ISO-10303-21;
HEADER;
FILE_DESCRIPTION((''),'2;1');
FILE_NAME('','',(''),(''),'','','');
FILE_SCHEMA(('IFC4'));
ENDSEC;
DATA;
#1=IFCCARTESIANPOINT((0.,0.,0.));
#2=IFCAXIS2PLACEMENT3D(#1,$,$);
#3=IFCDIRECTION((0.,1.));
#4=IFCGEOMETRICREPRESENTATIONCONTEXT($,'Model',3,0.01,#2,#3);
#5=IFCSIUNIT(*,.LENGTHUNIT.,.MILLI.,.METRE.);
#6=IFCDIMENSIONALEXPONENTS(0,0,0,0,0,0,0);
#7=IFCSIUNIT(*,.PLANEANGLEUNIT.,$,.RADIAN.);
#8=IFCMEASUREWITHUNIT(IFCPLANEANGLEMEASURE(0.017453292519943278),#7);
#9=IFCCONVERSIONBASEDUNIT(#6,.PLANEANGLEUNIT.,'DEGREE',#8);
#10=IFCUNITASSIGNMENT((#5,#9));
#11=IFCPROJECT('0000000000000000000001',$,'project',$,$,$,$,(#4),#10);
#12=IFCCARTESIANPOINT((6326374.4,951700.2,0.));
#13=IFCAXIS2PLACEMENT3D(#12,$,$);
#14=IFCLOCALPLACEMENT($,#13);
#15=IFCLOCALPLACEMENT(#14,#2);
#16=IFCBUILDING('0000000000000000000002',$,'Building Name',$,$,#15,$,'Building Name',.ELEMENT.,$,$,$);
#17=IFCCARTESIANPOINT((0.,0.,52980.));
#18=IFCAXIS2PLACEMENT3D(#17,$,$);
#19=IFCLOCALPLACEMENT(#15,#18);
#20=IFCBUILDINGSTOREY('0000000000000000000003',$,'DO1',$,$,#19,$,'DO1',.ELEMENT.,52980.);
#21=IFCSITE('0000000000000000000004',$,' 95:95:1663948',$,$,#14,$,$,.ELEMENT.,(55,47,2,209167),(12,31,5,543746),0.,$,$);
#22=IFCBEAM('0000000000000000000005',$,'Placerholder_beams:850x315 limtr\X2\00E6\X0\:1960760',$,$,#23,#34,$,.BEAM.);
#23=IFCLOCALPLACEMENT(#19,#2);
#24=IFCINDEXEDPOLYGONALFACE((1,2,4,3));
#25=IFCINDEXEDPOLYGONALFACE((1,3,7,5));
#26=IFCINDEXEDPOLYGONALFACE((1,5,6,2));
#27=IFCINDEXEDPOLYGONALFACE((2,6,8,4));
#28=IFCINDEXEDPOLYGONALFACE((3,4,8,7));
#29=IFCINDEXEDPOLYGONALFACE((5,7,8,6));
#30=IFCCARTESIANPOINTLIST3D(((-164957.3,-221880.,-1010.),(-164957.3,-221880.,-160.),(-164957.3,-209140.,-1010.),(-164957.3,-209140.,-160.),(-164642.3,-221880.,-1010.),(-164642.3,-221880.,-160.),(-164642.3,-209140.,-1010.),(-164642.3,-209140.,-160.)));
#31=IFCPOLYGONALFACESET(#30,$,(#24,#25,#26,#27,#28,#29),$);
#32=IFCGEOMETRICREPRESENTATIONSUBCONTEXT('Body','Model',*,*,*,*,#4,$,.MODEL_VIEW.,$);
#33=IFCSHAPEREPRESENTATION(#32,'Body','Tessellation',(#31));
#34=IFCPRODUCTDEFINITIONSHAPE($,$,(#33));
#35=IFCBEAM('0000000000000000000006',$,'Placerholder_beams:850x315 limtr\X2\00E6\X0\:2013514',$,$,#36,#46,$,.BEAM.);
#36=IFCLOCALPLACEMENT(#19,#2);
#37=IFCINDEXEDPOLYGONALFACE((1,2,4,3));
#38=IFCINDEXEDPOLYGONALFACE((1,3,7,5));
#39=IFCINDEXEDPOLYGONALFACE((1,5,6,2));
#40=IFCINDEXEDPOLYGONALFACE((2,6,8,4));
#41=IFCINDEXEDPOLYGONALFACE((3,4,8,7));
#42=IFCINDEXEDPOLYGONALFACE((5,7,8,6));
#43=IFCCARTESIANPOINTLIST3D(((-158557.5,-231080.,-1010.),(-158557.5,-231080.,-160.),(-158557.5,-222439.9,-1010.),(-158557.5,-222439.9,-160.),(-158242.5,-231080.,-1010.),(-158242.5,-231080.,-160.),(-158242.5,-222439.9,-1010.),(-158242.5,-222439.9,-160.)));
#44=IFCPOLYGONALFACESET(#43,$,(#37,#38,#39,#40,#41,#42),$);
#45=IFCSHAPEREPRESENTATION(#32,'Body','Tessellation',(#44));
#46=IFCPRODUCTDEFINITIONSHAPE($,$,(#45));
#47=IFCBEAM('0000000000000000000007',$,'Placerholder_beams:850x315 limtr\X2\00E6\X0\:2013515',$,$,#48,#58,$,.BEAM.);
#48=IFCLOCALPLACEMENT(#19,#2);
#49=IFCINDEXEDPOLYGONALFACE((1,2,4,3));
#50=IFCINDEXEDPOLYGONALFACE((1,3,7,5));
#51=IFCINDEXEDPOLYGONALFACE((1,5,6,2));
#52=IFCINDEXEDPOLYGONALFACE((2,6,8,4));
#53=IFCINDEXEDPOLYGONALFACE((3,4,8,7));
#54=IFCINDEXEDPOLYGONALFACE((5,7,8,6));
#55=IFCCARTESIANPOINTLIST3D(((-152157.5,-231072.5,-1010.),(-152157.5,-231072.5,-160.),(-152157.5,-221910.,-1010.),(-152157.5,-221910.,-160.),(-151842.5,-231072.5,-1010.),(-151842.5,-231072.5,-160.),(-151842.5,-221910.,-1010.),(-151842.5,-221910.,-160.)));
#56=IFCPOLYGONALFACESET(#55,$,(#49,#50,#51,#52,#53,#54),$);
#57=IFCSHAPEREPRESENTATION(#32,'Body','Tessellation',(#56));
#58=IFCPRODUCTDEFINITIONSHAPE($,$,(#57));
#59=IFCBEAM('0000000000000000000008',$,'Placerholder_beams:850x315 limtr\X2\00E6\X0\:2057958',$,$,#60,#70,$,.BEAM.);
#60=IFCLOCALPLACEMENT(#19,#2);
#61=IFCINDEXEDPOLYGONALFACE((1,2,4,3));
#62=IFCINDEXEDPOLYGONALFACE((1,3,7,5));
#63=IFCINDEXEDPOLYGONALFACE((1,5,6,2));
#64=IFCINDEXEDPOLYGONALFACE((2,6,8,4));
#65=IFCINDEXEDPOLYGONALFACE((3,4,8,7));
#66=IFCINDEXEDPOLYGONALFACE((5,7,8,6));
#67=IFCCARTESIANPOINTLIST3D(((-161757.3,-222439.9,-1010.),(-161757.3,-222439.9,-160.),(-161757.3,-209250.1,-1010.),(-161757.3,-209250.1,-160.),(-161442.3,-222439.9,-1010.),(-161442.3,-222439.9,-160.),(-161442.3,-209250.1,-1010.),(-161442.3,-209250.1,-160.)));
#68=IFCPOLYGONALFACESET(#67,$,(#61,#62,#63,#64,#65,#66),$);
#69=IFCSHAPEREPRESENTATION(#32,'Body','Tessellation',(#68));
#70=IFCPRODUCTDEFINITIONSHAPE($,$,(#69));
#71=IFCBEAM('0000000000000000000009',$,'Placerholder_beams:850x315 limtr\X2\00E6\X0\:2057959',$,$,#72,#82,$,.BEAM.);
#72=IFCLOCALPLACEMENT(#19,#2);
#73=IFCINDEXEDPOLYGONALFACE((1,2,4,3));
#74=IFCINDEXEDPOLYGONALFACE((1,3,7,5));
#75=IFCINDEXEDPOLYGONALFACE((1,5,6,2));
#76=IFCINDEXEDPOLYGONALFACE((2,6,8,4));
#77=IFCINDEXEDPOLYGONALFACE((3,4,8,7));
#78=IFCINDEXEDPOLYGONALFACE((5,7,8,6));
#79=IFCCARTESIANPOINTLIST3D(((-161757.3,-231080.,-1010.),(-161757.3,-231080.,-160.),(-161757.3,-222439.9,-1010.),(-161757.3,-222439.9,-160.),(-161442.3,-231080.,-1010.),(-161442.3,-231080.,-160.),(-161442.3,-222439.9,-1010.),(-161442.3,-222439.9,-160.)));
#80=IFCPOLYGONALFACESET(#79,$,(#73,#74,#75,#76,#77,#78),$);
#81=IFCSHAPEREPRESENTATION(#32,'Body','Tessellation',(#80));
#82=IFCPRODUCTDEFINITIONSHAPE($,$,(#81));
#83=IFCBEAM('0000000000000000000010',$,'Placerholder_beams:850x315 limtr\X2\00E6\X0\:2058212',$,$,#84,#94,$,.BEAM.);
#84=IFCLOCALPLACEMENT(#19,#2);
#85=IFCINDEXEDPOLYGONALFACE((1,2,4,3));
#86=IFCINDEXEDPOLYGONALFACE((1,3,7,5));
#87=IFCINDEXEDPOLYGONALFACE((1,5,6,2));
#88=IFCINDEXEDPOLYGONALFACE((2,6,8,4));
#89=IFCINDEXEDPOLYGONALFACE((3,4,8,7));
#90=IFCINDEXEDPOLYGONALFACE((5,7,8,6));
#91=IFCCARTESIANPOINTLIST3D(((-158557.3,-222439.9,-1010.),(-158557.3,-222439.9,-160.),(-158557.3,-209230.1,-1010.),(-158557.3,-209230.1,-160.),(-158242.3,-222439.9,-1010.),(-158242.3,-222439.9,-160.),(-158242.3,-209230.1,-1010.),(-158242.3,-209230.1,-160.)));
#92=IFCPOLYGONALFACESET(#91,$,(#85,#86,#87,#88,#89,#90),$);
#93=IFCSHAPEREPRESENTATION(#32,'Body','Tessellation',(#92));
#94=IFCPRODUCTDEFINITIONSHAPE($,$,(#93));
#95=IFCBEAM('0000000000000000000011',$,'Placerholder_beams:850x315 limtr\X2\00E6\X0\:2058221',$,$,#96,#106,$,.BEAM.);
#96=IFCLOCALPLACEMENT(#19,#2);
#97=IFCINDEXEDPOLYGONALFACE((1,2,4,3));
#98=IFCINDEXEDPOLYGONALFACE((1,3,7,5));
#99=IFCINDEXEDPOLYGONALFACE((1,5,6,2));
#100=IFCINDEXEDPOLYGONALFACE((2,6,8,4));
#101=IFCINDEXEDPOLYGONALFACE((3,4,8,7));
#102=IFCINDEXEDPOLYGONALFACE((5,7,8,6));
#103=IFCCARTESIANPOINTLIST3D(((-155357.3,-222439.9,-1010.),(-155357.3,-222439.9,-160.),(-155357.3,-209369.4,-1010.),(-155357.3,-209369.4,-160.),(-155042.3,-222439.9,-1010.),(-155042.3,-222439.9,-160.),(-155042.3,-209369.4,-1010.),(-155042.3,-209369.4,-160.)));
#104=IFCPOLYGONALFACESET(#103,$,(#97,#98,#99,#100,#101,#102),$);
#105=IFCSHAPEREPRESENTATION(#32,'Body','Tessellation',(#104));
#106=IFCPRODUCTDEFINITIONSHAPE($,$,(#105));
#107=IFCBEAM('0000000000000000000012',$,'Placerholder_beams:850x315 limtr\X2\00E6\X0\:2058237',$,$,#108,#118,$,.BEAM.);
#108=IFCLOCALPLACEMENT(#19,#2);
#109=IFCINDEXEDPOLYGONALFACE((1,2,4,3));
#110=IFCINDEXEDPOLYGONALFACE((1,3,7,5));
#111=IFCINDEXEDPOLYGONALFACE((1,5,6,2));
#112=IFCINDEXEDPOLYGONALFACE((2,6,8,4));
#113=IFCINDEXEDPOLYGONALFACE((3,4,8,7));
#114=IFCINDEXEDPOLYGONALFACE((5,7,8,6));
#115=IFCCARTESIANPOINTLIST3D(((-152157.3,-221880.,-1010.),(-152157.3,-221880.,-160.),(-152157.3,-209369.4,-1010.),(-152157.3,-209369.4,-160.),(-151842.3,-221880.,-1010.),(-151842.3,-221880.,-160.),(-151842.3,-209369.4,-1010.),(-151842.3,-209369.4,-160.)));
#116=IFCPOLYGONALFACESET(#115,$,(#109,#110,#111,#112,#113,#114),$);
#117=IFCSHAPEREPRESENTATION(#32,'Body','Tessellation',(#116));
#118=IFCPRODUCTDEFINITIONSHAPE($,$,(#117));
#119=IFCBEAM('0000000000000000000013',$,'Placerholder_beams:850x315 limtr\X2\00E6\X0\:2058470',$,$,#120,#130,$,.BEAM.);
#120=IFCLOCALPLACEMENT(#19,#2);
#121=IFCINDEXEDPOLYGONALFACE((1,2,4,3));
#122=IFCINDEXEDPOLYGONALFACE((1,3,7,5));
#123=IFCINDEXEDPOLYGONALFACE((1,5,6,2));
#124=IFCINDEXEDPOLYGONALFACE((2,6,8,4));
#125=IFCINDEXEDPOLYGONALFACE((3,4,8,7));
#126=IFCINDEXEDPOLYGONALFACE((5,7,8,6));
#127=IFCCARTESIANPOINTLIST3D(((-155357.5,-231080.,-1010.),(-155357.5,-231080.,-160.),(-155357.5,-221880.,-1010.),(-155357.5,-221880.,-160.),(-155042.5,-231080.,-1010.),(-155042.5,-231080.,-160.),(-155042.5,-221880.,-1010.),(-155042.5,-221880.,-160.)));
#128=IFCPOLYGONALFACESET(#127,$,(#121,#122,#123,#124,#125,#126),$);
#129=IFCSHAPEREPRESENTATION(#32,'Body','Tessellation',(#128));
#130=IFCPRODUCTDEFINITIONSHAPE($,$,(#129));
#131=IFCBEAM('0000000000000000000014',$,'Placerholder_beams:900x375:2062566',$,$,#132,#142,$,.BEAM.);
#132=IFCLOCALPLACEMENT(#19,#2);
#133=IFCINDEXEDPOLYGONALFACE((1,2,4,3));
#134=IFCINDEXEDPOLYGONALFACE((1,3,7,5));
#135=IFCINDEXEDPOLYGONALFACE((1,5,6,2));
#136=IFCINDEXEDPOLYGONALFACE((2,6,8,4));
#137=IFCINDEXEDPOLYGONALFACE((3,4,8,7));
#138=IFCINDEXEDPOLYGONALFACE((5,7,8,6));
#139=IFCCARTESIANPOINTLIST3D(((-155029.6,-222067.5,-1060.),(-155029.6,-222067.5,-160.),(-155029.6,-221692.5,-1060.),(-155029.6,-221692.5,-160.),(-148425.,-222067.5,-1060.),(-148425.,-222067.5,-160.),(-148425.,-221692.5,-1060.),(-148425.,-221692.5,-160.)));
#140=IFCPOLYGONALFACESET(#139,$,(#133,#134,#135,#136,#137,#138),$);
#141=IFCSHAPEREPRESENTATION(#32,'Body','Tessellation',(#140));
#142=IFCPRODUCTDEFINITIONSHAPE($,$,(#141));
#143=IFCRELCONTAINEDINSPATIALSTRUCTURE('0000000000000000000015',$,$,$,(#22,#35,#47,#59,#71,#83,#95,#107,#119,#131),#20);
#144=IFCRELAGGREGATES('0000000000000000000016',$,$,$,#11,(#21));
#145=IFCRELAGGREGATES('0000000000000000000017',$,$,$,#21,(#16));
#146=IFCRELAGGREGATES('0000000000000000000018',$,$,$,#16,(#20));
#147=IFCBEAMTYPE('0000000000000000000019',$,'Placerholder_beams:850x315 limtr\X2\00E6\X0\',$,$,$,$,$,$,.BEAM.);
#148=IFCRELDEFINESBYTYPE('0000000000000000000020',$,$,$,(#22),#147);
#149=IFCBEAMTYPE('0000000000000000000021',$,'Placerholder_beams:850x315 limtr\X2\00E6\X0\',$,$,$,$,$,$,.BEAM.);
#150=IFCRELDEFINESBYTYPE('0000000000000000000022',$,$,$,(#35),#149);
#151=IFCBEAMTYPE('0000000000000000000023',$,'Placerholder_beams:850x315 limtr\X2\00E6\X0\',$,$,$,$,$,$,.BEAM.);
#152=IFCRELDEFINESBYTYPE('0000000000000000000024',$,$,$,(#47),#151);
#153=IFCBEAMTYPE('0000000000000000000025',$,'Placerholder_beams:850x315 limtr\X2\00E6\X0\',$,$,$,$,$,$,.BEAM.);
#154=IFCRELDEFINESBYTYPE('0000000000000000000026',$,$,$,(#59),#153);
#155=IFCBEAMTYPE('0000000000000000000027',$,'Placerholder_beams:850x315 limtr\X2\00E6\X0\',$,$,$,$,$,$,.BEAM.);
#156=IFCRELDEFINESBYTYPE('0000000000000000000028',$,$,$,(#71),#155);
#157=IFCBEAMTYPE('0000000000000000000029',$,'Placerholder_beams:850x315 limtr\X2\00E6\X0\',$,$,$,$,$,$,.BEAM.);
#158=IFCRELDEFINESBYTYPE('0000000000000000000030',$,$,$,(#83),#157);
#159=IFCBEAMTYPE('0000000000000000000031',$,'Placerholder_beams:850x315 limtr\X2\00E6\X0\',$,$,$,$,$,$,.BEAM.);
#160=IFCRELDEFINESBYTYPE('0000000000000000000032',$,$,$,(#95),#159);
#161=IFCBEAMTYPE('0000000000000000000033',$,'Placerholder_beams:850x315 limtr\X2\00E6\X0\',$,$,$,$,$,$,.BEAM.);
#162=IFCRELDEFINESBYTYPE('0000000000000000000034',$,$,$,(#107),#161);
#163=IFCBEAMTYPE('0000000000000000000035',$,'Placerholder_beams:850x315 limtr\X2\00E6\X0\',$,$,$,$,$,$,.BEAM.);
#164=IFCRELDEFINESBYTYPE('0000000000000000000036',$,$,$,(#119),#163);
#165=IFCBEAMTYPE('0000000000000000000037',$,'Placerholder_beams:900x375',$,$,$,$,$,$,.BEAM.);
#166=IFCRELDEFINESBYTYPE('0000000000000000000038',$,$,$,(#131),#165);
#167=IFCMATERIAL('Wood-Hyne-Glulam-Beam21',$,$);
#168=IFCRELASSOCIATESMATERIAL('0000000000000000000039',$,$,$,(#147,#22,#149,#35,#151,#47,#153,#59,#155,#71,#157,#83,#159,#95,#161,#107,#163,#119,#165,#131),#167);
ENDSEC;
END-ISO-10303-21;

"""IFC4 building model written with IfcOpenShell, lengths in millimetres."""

from ifc_helpers import new_model, entity, si_unit, converted_unit, direction, frame, origin, place, context, subcontext, project, spatial, indexed_curve, outline, extrude, source, transform, mapped, material, type_object, type_shapes, element, save


model = new_model("IFC4")

# Units and contexts
model_context = context("Model", 3, precision=0.01, world=origin(), true_north=direction((0.0, 1.0)))
body_context = subcontext(model_context, "Body", "Model", "MODEL_VIEW")
ifc_project = project(units=[si_unit("LENGTHUNIT", "METRE", prefix="MILLI"), converted_unit("PLANEANGLEUNIT", "DEGREE", entity("IfcPlaneAngleMeasure", 0.017453292519943278), si_unit("PLANEANGLEUNIT", "RADIAN"), dimensions=[0, 0, 0, 0, 0, 0, 0])], contexts=[model_context])

# Site, building, storey
site_placement = place(None, frame((6326374.4, 951700.2, 0.0)))
site = spatial("IfcSite", under=ifc_project, at=site_placement, Name=" 95:95:1663948", CompositionType="ELEMENT", RefLatitude=(55, 47, 2, 209167), RefLongitude=(12, 31, 5, 543746), RefElevation=0.0)
building_placement = place(site_placement, origin())
building = spatial("IfcBuilding", under=site, at=building_placement, Name="Building Name", LongName="Building Name", CompositionType="ELEMENT")
storey_placement = place(building_placement, frame((0.0, 0.0, 52980.0)))
storey = spatial("IfcBuildingStorey", under=building, at=storey_placement, Name="DO1", LongName="DO1", CompositionType="ELEMENT", Elevation=52980.0)

# Beams
ifc_material = material(Name="Wood-Hyne-Glulam-Beam21")
beam_type_1 = type_object("IfcBeamType", Name="Placerholder_beams:850x315 limtræ", PredefinedType="BEAM", material=ifc_material)
shared_shape_1 = source(origin(), body_context, "Body", "SweptSolid", [
    extrude(outline(indexed_curve([(-6370.0, -157.5), (6370.0, -157.5), (6370.0, 157.5), (-6370.0, 157.5), (-6370.0, -157.5)], self_intersect=False)), frame((110.0, 0.0, -425.0)), (0.0, 0.0, 1.0), 850.0),
])
type_shapes(beam_type_1, [shared_shape_1])
beam_1_placement = place(storey_placement, frame((-164799.8, -215620.0, -585.0), z_axis=(0.0, 0.0, 1.0), x_axis=(0.0, 1.0, 0.0)))
element("IfcBeam", 1, at=beam_1_placement, inside=storey, type_object=beam_type_1, material=ifc_material, Name="Placerholder_beams:850x315 limtræ:1960760", PredefinedType="BEAM", context=body_context, shape_type="MappedRepresentation", body=[
    mapped(shared_shape_1, transform((0.0, 0.0, 0.0), scale=1.0)),
])
beam_type_2 = type_object("IfcBeamType", Name="Placerholder_beams:850x315 limtræ", PredefinedType="BEAM", material=ifc_material)
shared_shape_2 = source(origin(), body_context, "Body", "SweptSolid", [
    extrude(outline(indexed_curve([(-4320.0, -157.5), (4320.0, -157.5), (4320.0, 157.5), (-4320.0, 157.5), (-4320.0, -157.5)], self_intersect=False)), frame((280.0, 0.0, -425.0)), (0.0, 0.0, 1.0), 850.0),
])
type_shapes(beam_type_2, [shared_shape_2])
beam_2_placement = place(storey_placement, frame((-158400.0, -226480.0, -585.0), z_axis=(0.0, 0.0, 1.0), x_axis=(0.0, -1.0, 0.0)))
element("IfcBeam", 2, at=beam_2_placement, inside=storey, type_object=beam_type_2, material=ifc_material, Name="Placerholder_beams:850x315 limtræ:2013514", PredefinedType="BEAM", context=body_context, shape_type="MappedRepresentation", body=[
    mapped(shared_shape_2, transform((0.0, 0.0, 0.0), scale=1.0)),
])
beam_type_3 = type_object("IfcBeamType", Name="Placerholder_beams:850x315 limtræ", PredefinedType="BEAM", material=ifc_material)
shared_shape_3 = source(origin(), body_context, "Body", "SweptSolid", [
    extrude(outline(indexed_curve([(-4581.2, -157.5), (4581.2, -157.5), (4581.2, 157.5), (-4581.2, 157.5), (-4581.2, -157.5)], self_intersect=False)), frame((1588.8, 0.0, -425.0)), (0.0, 0.0, 1.0), 850.0),
])
type_shapes(beam_type_3, [shared_shape_3])
beam_3_placement = place(storey_placement, frame((-152000.0, -224902.5, -585.0), z_axis=(0.0, 0.0, 1.0), x_axis=(0.0, -1.0, 0.0)))
element("IfcBeam", 3, at=beam_3_placement, inside=storey, type_object=beam_type_3, material=ifc_material, Name="Placerholder_beams:850x315 limtræ:2013515", PredefinedType="BEAM", context=body_context, shape_type="MappedRepresentation", body=[
    mapped(shared_shape_3, transform((0.0, 0.0, 0.0), scale=1.0)),
])
beam_type_4 = type_object("IfcBeamType", Name="Placerholder_beams:850x315 limtræ", PredefinedType="BEAM", material=ifc_material)
shared_shape_4 = source(origin(), body_context, "Body", "SweptSolid", [
    extrude(outline(indexed_curve([(-6594.9, -157.5), (6594.9, -157.5), (6594.9, 157.5), (-6594.9, 157.5), (-6594.9, -157.5)], self_intersect=False)), frame((55.0, 0.0, -425.0)), (0.0, 0.0, 1.0), 850.0),
])
type_shapes(beam_type_4, [shared_shape_4])
beam_4_placement = place(storey_placement, frame((-161599.8, -215900.0, -585.0), z_axis=(0.0, 0.0, 1.0), x_axis=(0.0, 1.0, 0.0)))
element("IfcBeam", 4, at=beam_4_placement, inside=storey, type_object=beam_type_4, material=ifc_material, Name="Placerholder_beams:850x315 limtræ:2057958", PredefinedType="BEAM", context=body_context, shape_type="MappedRepresentation", body=[
    mapped(shared_shape_4, transform((0.0, 0.0, 0.0), scale=1.0)),
])
beam_type_5 = type_object("IfcBeamType", Name="Placerholder_beams:850x315 limtræ", PredefinedType="BEAM", material=ifc_material)
shared_shape_5 = source(origin(), body_context, "Body", "SweptSolid", [
    extrude(outline(indexed_curve([(-4320.0, -157.5), (4320.0, -157.5), (4320.0, 157.5), (-4320.0, 157.5), (-4320.0, -157.5)], self_intersect=False)), frame((0.0, 0.0, -425.0)), (0.0, 0.0, 1.0), 850.0),
])
type_shapes(beam_type_5, [shared_shape_5])
beam_5_placement = place(storey_placement, frame((-161599.8, -226760.0, -585.0), z_axis=(0.0, 0.0, 1.0), x_axis=(0.0, 1.0, 0.0)))
element("IfcBeam", 5, at=beam_5_placement, inside=storey, type_object=beam_type_5, material=ifc_material, Name="Placerholder_beams:850x315 limtræ:2057959", PredefinedType="BEAM", context=body_context, shape_type="MappedRepresentation", body=[
    mapped(shared_shape_5, transform((0.0, 0.0, 0.0), scale=1.0)),
])
beam_type_6 = type_object("IfcBeamType", Name="Placerholder_beams:850x315 limtræ", PredefinedType="BEAM", material=ifc_material)
shared_shape_6 = source(origin(), body_context, "Body", "SweptSolid", [
    extrude(outline(indexed_curve([(-6604.9, -157.5), (6604.9, -157.5), (6604.9, 157.5), (-6604.9, 157.5), (-6604.9, -157.5)], self_intersect=False)), frame((65.0, 0.0, -425.0)), (0.0, 0.0, 1.0), 850.0),
])
type_shapes(beam_type_6, [shared_shape_6])
beam_6_placement = place(storey_placement, frame((-158399.8, -215900.0, -585.0), z_axis=(0.0, 0.0, 1.0), x_axis=(0.0, 1.0, 0.0)))
element("IfcBeam", 6, at=beam_6_placement, inside=storey, type_object=beam_type_6, material=ifc_material, Name="Placerholder_beams:850x315 limtræ:2058212", PredefinedType="BEAM", context=body_context, shape_type="MappedRepresentation", body=[
    mapped(shared_shape_6, transform((0.0, 0.0, 0.0), scale=1.0)),
])
beam_type_7 = type_object("IfcBeamType", Name="Placerholder_beams:850x315 limtræ", PredefinedType="BEAM", material=ifc_material)
shared_shape_7 = source(origin(), body_context, "Body", "SweptSolid", [
    extrude(outline(indexed_curve([(-6535.3, -157.5), (6535.3, -157.5), (6535.3, 157.5), (-6535.3, 157.5), (-6535.3, -157.5)], self_intersect=False)), frame((-4.7, 0.0, -425.0)), (0.0, 0.0, 1.0), 850.0),
])
type_shapes(beam_type_7, [shared_shape_7])
beam_7_placement = place(storey_placement, frame((-155199.8, -215900.0, -585.0), z_axis=(0.0, 0.0, 1.0), x_axis=(0.0, 1.0, 0.0)))
element("IfcBeam", 7, at=beam_7_placement, inside=storey, type_object=beam_type_7, material=ifc_material, Name="Placerholder_beams:850x315 limtræ:2058221", PredefinedType="BEAM", context=body_context, shape_type="MappedRepresentation", body=[
    mapped(shared_shape_7, transform((0.0, 0.0, 0.0), scale=1.0)),
])
beam_type_8 = type_object("IfcBeamType", Name="Placerholder_beams:850x315 limtræ", PredefinedType="BEAM", material=ifc_material)
shared_shape_8 = source(origin(), body_context, "Body", "SweptSolid", [
    extrude(outline(indexed_curve([(-6255.3, -157.5), (6255.3, -157.5), (6255.3, 157.5), (-6255.3, 157.5), (-6255.3, -157.5)], self_intersect=False)), frame((275.3, 0.0, -425.0)), (0.0, 0.0, 1.0), 850.0),
])
type_shapes(beam_type_8, [shared_shape_8])
beam_8_placement = place(storey_placement, frame((-151999.8, -215900.0, -585.0), z_axis=(0.0, 0.0, 1.0), x_axis=(0.0, 1.0, 0.0)))
element("IfcBeam", 8, at=beam_8_placement, inside=storey, type_object=beam_type_8, material=ifc_material, Name="Placerholder_beams:850x315 limtræ:2058237", PredefinedType="BEAM", context=body_context, shape_type="MappedRepresentation", body=[
    mapped(shared_shape_8, transform((0.0, 0.0, 0.0), scale=1.0)),
])
beam_type_9 = type_object("IfcBeamType", Name="Placerholder_beams:850x315 limtræ", PredefinedType="BEAM", material=ifc_material)
shared_shape_9 = source(origin(), body_context, "Body", "SweptSolid", [
    extrude(outline(indexed_curve([(-4600.0, -157.5), (4600.0, -157.5), (4600.0, 157.5), (-4600.0, 157.5), (-4600.0, -157.5)], self_intersect=False)), frame((0.0, 0.0, -425.0)), (0.0, 0.0, 1.0), 850.0),
])
type_shapes(beam_type_9, [shared_shape_9])
beam_9_placement = place(storey_placement, frame((-155200.0, -226480.0, -585.0), z_axis=(0.0, 0.0, 1.0), x_axis=(0.0, -1.0, 0.0)))
element("IfcBeam", 9, at=beam_9_placement, inside=storey, type_object=beam_type_9, material=ifc_material, Name="Placerholder_beams:850x315 limtræ:2058470", PredefinedType="BEAM", context=body_context, shape_type="MappedRepresentation", body=[
    mapped(shared_shape_9, transform((0.0, 0.0, 0.0), scale=1.0)),
])
beam_type_10 = type_object("IfcBeamType", Name="Placerholder_beams:900x375", PredefinedType="BEAM", material=ifc_material)
shared_shape_10 = source(origin(), body_context, "Body", "SweptSolid", [
    extrude(outline(indexed_curve([(-3302.3, -187.5), (3302.3, -187.5), (3302.3, 187.5), (-3302.3, 187.5), (-3302.3, -187.5)], self_intersect=False)), frame((85.1, 0.0, -450.0)), (0.0, 0.0, 1.0), 900.0),
])
type_shapes(beam_type_10, [shared_shape_10])
beam_10_placement = place(storey_placement, frame((-151812.4, -221880.0, -610.0)))
element("IfcBeam", 10, at=beam_10_placement, inside=storey, type_object=beam_type_10, material=ifc_material, Name="Placerholder_beams:900x375:2062566", PredefinedType="BEAM", context=body_context, shape_type="MappedRepresentation", body=[
    mapped(shared_shape_10, transform((0.0, 0.0, 0.0), scale=1.0)),
])

save(model, "model.ifc")
